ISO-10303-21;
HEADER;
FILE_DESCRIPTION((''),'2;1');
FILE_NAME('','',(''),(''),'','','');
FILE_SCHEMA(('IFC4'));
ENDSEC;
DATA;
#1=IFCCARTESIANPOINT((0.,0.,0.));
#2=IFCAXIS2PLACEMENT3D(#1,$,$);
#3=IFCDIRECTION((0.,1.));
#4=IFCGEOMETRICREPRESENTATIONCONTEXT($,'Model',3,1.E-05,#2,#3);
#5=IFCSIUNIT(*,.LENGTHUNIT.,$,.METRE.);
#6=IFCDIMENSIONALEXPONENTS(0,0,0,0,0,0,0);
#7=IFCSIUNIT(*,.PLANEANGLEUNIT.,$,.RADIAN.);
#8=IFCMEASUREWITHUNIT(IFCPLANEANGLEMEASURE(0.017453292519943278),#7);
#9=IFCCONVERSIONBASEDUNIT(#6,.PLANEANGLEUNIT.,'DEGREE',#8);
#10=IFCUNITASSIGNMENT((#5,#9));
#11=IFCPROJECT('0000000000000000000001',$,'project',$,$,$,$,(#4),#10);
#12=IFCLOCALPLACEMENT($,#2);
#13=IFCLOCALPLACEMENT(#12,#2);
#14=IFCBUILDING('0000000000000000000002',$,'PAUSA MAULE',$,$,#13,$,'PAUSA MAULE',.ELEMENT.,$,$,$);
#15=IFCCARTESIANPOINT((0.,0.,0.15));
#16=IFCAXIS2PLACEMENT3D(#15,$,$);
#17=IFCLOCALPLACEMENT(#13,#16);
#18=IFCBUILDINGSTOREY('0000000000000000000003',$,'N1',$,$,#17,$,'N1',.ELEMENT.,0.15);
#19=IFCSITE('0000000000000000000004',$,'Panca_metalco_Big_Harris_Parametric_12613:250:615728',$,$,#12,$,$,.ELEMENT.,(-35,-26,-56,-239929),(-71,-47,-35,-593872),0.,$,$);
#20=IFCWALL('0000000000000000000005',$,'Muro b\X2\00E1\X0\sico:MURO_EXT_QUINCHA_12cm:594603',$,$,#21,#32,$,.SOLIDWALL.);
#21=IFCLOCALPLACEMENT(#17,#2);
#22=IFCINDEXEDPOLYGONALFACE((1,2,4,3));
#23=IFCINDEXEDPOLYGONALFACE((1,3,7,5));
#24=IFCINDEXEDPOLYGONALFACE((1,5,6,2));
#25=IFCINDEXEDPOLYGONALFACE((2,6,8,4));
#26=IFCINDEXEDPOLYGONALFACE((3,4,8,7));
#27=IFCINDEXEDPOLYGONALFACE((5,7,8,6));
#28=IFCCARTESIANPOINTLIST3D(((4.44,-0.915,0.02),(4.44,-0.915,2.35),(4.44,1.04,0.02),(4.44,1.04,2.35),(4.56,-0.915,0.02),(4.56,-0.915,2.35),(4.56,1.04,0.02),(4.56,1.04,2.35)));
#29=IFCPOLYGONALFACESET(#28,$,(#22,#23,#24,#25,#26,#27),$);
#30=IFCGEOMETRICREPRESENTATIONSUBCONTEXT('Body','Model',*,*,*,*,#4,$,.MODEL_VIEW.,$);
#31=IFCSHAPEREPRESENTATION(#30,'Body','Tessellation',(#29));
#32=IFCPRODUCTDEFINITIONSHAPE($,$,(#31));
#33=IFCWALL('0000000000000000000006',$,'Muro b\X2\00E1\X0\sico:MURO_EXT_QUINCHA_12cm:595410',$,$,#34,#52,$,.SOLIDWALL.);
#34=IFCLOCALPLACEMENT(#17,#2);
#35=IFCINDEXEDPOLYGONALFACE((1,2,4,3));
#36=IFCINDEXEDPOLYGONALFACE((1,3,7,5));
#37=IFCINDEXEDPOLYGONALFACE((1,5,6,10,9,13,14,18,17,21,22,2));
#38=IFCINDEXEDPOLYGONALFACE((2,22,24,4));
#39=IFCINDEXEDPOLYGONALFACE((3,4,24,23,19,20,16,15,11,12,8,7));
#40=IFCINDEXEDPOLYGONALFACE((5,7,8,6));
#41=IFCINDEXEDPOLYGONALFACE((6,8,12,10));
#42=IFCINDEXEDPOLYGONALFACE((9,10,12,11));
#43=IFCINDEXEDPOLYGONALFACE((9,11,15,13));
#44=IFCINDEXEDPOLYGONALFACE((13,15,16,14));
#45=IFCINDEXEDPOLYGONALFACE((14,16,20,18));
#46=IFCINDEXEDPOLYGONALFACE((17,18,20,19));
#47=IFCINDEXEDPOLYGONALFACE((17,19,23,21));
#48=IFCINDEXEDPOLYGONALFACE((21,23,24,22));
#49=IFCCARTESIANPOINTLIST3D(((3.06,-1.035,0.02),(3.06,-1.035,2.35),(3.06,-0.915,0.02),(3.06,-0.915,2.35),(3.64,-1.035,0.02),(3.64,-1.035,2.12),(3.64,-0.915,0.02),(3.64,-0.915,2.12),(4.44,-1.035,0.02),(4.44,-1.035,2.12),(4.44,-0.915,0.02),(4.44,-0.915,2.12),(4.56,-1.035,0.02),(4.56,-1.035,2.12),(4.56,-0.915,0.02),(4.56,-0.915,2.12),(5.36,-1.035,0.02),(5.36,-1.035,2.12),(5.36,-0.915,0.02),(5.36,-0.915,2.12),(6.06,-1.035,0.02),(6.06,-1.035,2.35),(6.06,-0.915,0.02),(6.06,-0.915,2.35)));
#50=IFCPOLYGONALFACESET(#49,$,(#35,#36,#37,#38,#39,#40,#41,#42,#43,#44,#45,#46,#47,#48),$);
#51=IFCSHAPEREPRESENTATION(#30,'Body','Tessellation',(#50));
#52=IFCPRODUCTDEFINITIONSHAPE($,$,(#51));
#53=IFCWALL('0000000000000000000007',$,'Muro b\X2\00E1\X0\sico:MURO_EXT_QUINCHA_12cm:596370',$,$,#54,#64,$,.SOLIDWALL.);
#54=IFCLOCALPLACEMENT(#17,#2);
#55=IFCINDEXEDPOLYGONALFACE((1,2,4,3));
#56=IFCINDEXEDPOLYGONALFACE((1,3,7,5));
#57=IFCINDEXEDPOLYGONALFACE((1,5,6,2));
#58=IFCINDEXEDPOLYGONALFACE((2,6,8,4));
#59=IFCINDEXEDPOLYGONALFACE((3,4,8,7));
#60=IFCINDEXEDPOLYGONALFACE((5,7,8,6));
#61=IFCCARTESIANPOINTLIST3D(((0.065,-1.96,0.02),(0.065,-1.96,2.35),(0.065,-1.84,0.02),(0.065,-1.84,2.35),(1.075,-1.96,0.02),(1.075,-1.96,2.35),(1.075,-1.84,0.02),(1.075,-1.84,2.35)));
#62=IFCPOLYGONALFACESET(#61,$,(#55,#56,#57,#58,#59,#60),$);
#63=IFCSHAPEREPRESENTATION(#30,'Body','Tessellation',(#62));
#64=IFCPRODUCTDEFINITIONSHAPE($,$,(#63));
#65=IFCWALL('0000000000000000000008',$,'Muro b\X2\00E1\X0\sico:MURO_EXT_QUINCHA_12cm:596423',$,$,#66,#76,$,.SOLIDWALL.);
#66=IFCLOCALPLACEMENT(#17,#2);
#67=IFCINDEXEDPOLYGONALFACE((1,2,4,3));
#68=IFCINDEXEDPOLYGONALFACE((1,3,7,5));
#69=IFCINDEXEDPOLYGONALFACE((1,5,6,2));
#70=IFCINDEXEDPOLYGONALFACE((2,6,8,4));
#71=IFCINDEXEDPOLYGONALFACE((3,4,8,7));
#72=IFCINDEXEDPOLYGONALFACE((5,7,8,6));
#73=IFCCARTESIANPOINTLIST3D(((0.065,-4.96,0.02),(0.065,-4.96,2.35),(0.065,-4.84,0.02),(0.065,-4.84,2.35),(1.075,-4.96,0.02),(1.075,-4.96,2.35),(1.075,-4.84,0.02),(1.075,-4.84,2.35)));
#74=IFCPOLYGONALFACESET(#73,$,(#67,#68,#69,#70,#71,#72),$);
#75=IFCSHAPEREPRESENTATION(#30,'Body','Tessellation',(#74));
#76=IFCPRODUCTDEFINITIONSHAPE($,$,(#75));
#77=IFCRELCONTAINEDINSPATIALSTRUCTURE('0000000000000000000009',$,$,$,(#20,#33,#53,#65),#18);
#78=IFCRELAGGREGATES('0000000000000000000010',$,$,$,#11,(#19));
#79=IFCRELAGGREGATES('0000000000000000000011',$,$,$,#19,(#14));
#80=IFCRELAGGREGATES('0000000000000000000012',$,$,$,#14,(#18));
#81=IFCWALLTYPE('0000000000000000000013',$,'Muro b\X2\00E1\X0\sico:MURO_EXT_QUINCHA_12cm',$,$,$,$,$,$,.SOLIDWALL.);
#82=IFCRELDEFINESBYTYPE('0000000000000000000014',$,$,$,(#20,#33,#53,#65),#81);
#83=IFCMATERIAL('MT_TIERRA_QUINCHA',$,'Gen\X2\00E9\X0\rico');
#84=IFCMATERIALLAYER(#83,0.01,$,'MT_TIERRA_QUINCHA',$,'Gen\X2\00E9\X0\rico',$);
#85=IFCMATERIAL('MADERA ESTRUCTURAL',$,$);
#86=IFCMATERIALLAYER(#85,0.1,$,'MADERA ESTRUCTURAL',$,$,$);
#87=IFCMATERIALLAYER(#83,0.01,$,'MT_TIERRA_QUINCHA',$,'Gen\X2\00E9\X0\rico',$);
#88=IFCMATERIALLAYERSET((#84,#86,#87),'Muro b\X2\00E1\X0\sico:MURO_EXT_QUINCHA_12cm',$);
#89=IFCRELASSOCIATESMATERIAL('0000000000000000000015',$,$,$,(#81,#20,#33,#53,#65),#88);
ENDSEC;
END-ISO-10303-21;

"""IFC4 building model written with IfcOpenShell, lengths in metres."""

from ifc_helpers import new_model, entity, si_unit, converted_unit, direction, frame, frame_2d, origin, place, context, subcontext, project, spatial, rectangle, extrude, material, layer, layer_set, layer_usage, type_object, element, save


model = new_model("IFC4")

# Units and contexts
model_context = context("Model", 3, precision=1e-05, world=origin(), true_north=direction((0.0, 1.0)))
body_context = subcontext(model_context, "Body", "Model", "MODEL_VIEW")
ifc_project = project(units=[si_unit("LENGTHUNIT", "METRE"), converted_unit("PLANEANGLEUNIT", "DEGREE", entity("IfcPlaneAngleMeasure", 0.017453292519943278), si_unit("PLANEANGLEUNIT", "RADIAN"), dimensions=[0, 0, 0, 0, 0, 0, 0])], contexts=[model_context])

# Site, building, storey
site_placement = place(None, origin())
site = spatial("IfcSite", under=ifc_project, at=site_placement, Name="Panca_metalco_Big_Harris_Parametric_12613:250:615728", CompositionType="ELEMENT", RefLatitude=(-35, -26, -56, -239929), RefLongitude=(-71, -47, -35, -593872), RefElevation=0.0)
building_placement = place(site_placement, origin())
building = spatial("IfcBuilding", under=site, at=building_placement, Name="PAUSA MAULE", LongName="PAUSA MAULE", CompositionType="ELEMENT")
storey_placement = place(building_placement, frame((0.0, 0.0, 0.15)))
storey = spatial("IfcBuildingStorey", under=building, at=storey_placement, Name="N1", LongName="N1", CompositionType="ELEMENT", Elevation=0.15)

# Wall
ifc_material_1 = material(Name="MT_TIERRA_QUINCHA", Category="Genérico")
ifc_layer_1 = layer(ifc_material_1, 0.01, Name="MT_TIERRA_QUINCHA", Category="Genérico")
ifc_material_2 = material(Name="MADERA ESTRUCTURAL")
ifc_layer_2 = layer(ifc_material_2, 0.1, Name="MADERA ESTRUCTURAL")
ifc_layer_3 = layer(ifc_material_1, 0.01, Name="MT_TIERRA_QUINCHA", Category="Genérico")
ifc_layer_set_1 = layer_set([ifc_layer_1, ifc_layer_2, ifc_layer_3], Name="Muro básico:MURO_EXT_QUINCHA_12cm")
wall_type = type_object("IfcWallType", Name="Muro básico:MURO_EXT_QUINCHA_12cm", PredefinedType="SOLIDWALL", material=ifc_layer_set_1)
ifc_layer_usage_1 = layer_usage(ifc_layer_set_1, "AXIS2", "NEGATIVE", 0.06)
wall_1_placement = place(storey_placement, frame((4.5, 1.04, 0.02), z_axis=(0.0, 0.0, 1.0), x_axis=(0.0, -1.0, 0.0)))
element("IfcWall", 1, at=wall_1_placement, inside=storey, type_object=wall_type, material=ifc_layer_usage_1, Name="Muro básico:MURO_EXT_QUINCHA_12cm:594603", PredefinedType="SOLIDWALL", context=body_context, shape_type="SweptSolid", body=[
    extrude(rectangle(XDim=1.955, YDim=0.12, at=frame_2d((0.9775, 0.0), x_axis=(-1.0, 0.0))), origin(), (0.0, 0.0, 1.0), 2.33),
])

# Wall, openings
ifc_layer_usage_2 = layer_usage(ifc_layer_set_1, "AXIS2", "NEGATIVE", 0.06)
wall_2_placement = place(storey_placement, frame((3.06, -0.975, 0.02)))
wall_2 = element("IfcWall", 2, at=wall_2_placement, inside=storey, type_object=wall_type, material=ifc_layer_usage_2, Name="Muro básico:MURO_EXT_QUINCHA_12cm:595410", PredefinedType="SOLIDWALL", context=body_context, shape_type="SweptSolid", body=[
    extrude(rectangle(XDim=3.0, YDim=0.12, at=frame_2d((1.5, 0.0), x_axis=(-1.0, 0.0))), origin(), (0.0, 0.0, 1.0), 2.33),
])
opening_1_placement = place(wall_2_placement, frame((1.5, -0.06, 0.0)))
element("IfcOpeningElement", 3, at=opening_1_placement, cuts=wall_2, PredefinedType="OPENING", context=body_context, shape_type="SweptSolid", body=[
    extrude(rectangle(XDim=2.1, YDim=0.8, at=frame_2d((1.05, 0.4), x_axis=(1.0, 0.0))), frame((0.0, 0.0, 0.0), z_axis=(0.0, 1.0, 0.0), x_axis=(0.0, 0.0, 1.0)), (0.0, 0.0, 1.0), 0.12),
])
opening_2_placement = place(wall_2_placement, frame((0.58, -0.06, 0.0)))
element("IfcOpeningElement", 4, at=opening_2_placement, cuts=wall_2, PredefinedType="OPENING", context=body_context, shape_type="SweptSolid", body=[
    extrude(rectangle(XDim=2.1, YDim=0.8, at=frame_2d((1.05, 0.4), x_axis=(1.0, 0.0))), frame((0.0, 0.0, 0.0), z_axis=(0.0, 1.0, 0.0), x_axis=(0.0, 0.0, 1.0)), (0.0, 0.0, 1.0), 0.12),
])

# Walls
ifc_layer_usage_3 = layer_usage(ifc_layer_set_1, "AXIS2", "NEGATIVE", 0.06)
wall_3_placement = place(storey_placement, frame((0.065, -1.9, 0.02)))
element("IfcWall", 5, at=wall_3_placement, inside=storey, type_object=wall_type, material=ifc_layer_usage_3, Name="Muro básico:MURO_EXT_QUINCHA_12cm:596370", PredefinedType="SOLIDWALL", context=body_context, shape_type="SweptSolid", body=[
    extrude(rectangle(XDim=1.01, YDim=0.12, at=frame_2d((0.505, 0.0), x_axis=(-1.0, 0.0))), origin(), (0.0, 0.0, 1.0), 2.33),
])
ifc_layer_usage_4 = layer_usage(ifc_layer_set_1, "AXIS2", "NEGATIVE", 0.06)
wall_4_placement = place(storey_placement, frame((0.065, -4.9, 0.02)))
element("IfcWall", 6, at=wall_4_placement, inside=storey, type_object=wall_type, material=ifc_layer_usage_4, Name="Muro básico:MURO_EXT_QUINCHA_12cm:596423", PredefinedType="SOLIDWALL", context=body_context, shape_type="SweptSolid", body=[
    extrude(rectangle(XDim=1.01, YDim=0.12, at=frame_2d((0.505, 0.0), x_axis=(-1.0, 0.0))), origin(), (0.0, 0.0, 1.0), 2.33),
])

save(model, "model.ifc")
